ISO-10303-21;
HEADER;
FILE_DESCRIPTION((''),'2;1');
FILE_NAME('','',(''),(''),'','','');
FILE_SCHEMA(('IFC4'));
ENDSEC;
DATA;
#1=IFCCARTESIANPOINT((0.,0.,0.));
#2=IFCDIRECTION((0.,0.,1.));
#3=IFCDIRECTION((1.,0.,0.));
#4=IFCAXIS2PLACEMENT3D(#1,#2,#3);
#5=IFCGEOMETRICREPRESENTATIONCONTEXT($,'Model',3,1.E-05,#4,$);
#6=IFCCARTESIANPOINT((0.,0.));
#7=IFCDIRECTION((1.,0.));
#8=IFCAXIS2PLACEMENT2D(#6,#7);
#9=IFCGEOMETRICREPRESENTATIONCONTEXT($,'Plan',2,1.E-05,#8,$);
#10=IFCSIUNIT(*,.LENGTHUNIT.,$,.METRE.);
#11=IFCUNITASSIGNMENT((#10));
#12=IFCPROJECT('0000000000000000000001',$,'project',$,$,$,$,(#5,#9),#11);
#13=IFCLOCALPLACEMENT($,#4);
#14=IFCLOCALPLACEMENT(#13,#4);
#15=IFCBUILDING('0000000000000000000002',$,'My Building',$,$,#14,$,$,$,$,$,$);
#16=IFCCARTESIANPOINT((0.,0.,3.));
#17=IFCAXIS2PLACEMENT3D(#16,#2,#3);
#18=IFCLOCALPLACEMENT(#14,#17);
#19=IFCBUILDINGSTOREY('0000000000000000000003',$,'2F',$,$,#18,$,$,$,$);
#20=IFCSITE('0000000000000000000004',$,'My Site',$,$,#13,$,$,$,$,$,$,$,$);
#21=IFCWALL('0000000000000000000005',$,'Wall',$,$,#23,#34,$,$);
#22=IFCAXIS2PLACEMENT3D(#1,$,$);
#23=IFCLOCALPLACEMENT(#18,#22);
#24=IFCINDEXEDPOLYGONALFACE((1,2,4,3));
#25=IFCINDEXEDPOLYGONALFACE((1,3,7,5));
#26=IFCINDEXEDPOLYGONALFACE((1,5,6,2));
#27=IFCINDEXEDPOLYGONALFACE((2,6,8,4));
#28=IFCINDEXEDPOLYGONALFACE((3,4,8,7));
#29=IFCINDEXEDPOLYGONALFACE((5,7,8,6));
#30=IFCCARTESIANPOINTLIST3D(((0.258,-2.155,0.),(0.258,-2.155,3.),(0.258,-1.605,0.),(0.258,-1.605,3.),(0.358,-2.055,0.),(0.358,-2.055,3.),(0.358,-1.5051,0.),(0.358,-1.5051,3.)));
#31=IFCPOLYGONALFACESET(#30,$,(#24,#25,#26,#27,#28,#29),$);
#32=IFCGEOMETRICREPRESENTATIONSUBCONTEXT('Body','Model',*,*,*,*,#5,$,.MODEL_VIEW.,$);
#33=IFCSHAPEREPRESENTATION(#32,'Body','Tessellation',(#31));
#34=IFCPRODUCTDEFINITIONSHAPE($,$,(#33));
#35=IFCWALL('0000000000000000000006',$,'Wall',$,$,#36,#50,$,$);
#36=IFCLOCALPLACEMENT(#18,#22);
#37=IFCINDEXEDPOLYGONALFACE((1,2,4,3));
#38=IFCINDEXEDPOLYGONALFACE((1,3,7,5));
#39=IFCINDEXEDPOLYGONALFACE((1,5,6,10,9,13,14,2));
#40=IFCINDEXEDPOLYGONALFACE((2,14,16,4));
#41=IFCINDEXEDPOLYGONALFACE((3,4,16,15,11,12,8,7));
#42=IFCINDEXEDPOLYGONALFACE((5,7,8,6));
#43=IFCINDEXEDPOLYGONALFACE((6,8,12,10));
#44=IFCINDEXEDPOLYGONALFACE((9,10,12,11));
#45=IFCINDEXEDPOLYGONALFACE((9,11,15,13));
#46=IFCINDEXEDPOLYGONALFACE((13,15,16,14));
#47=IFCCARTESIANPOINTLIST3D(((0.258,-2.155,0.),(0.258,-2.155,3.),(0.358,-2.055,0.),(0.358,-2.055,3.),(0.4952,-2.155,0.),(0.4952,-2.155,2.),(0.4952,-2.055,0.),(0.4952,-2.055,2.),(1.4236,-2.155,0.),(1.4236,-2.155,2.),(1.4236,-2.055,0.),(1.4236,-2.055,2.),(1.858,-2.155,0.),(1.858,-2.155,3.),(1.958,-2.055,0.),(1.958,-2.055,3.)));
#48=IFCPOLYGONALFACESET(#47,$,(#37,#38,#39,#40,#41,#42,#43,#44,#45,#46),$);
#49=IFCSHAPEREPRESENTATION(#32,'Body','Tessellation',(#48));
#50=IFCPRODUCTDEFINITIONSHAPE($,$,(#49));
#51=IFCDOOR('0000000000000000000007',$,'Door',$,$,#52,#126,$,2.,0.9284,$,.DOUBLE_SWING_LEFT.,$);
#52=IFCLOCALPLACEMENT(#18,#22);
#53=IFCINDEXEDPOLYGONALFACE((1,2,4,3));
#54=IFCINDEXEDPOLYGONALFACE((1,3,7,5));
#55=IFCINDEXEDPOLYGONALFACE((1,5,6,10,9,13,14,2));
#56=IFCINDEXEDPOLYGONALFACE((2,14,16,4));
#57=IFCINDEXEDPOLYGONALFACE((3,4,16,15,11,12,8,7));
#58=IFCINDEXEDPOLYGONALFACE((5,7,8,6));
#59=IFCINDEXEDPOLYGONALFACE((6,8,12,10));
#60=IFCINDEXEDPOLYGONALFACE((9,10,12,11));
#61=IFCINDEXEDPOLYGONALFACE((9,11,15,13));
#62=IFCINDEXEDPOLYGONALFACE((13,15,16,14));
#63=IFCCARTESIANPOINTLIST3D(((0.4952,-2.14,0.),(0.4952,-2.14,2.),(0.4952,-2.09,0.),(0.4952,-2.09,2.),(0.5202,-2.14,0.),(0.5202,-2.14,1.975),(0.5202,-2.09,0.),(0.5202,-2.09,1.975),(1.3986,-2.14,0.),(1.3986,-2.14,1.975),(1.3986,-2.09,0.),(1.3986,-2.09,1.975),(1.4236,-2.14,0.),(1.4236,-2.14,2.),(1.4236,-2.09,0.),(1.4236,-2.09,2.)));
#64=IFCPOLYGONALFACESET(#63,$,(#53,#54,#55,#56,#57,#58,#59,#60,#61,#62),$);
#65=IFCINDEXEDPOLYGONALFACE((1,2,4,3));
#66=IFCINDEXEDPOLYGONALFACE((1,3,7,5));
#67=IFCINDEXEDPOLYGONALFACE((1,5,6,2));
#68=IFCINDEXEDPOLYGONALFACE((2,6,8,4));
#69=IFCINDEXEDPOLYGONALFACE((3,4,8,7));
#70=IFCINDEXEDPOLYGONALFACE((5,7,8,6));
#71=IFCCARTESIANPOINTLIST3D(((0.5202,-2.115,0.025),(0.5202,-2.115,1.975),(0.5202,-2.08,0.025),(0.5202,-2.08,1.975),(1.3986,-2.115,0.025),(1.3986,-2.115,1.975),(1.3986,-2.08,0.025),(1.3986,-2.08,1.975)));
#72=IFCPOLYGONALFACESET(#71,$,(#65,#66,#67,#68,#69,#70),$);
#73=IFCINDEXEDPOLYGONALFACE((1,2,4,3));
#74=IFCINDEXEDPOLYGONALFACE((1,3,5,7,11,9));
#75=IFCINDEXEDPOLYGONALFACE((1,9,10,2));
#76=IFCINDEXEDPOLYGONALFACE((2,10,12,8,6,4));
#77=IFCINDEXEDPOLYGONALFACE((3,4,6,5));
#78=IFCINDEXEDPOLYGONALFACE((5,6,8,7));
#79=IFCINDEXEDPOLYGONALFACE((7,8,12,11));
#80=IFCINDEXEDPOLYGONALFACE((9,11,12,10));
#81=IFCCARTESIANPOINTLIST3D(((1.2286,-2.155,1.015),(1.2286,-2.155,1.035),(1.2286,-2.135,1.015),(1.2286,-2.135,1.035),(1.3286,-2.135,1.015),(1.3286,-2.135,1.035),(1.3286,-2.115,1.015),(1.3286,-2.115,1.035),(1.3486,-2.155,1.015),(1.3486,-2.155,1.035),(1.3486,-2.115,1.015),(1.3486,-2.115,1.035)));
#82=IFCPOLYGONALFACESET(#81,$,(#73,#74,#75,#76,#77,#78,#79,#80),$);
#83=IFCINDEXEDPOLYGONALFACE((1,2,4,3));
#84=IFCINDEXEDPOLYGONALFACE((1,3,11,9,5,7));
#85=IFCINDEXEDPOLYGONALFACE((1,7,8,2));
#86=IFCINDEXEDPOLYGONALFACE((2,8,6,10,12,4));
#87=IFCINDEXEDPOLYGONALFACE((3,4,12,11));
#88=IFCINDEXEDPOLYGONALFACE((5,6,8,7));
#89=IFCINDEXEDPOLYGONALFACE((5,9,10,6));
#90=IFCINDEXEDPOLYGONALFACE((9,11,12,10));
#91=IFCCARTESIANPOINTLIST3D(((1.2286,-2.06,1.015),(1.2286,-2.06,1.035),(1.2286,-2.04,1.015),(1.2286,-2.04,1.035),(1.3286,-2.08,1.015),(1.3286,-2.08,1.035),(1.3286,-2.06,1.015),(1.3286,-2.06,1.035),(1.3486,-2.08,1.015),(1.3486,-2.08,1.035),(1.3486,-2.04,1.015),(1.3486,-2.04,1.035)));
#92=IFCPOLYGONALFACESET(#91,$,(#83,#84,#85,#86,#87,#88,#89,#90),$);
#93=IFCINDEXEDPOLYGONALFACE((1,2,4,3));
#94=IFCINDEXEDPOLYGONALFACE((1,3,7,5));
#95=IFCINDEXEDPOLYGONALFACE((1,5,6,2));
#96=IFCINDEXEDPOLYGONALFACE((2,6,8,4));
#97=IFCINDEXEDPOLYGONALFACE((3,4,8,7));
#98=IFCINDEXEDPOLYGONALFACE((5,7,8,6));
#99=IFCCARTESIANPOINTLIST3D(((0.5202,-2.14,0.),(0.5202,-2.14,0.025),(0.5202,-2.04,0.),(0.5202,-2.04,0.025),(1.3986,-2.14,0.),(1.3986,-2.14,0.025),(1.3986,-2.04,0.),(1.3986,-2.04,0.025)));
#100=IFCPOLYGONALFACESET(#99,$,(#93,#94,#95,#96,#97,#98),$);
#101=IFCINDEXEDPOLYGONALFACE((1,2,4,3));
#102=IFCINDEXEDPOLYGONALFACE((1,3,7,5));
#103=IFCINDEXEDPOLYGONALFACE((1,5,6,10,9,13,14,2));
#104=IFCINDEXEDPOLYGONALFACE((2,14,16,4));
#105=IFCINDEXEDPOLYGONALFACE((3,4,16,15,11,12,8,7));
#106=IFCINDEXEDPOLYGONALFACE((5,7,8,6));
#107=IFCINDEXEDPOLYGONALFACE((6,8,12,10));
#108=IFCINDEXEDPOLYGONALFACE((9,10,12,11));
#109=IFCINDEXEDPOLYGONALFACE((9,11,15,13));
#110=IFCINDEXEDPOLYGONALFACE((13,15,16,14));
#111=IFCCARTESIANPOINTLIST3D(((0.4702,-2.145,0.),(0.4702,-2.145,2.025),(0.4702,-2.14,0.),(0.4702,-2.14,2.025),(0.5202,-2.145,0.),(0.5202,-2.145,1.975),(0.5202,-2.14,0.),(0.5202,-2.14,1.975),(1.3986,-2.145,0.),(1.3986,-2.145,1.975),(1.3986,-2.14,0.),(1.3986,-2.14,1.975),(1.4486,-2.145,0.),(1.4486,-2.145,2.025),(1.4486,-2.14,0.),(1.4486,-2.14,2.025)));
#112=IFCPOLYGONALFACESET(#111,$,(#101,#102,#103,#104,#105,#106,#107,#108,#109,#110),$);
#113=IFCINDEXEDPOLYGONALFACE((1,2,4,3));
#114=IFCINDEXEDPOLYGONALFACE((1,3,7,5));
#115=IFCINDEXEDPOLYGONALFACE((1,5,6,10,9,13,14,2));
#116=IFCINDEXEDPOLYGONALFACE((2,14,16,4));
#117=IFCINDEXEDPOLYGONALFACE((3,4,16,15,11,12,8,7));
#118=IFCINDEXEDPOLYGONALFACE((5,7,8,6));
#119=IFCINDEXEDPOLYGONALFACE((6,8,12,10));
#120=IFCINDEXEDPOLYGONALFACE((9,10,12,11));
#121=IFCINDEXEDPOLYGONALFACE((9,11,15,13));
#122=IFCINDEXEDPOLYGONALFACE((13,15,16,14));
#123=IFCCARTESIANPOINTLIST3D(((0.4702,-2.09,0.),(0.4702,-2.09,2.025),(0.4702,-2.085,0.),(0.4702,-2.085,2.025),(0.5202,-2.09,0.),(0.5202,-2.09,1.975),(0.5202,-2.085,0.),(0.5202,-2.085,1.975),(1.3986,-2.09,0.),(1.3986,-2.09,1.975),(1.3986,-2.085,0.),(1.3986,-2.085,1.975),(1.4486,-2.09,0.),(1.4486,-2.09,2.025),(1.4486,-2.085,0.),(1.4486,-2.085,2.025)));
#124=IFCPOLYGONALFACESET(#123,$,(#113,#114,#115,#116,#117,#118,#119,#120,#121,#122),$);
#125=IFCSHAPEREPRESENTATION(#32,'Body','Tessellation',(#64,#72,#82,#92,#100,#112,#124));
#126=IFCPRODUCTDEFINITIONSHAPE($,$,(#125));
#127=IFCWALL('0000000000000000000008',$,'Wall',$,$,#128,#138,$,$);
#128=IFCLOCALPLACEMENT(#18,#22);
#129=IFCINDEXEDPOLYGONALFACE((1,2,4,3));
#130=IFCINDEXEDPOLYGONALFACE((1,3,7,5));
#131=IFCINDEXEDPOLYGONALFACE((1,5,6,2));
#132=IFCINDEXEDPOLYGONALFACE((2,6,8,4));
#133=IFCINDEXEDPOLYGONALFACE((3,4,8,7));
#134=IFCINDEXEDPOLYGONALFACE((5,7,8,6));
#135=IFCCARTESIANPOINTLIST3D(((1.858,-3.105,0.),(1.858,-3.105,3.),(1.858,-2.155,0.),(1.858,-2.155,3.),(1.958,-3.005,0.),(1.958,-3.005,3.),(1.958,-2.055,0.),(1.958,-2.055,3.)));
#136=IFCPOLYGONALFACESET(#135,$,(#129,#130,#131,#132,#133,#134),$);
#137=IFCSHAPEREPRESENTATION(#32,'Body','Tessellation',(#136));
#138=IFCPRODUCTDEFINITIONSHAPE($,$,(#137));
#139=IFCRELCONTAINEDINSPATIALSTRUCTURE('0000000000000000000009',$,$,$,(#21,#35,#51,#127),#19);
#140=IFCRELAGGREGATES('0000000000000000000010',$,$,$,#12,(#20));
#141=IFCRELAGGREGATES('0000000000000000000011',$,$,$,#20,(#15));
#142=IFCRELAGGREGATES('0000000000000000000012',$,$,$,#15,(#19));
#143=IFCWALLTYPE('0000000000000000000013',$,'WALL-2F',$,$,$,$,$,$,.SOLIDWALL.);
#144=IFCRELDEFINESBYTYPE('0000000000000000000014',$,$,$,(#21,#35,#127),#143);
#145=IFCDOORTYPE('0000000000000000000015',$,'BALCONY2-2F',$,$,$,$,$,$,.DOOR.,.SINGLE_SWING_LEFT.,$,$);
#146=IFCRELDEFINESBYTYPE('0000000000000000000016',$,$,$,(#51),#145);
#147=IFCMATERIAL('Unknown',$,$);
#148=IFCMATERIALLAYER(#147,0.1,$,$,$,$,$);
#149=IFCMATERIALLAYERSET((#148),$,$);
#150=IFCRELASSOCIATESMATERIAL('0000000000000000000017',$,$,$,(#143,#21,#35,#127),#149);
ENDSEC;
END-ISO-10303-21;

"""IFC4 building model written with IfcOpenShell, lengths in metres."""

from ifc_helpers import new_model, entity, si_unit, frame, origin_with_axes, origin_2d_with_axis, place, context, subcontext, project, spatial, line, indexed_curve, outline, extrude, shape, source, transform, mapped, material, layer, layer_set, layer_usage, type_object, type_shapes, element, fill, save


model = new_model("IFC4")

# Units and contexts
model_context = context("Model", 3, precision=1e-05, world=origin_with_axes())
plan_context = context("Plan", 2, precision=1e-05, world=origin_2d_with_axis())
body_context_1 = subcontext(model_context, "Body", "Model", "MODEL_VIEW")
body_context_2 = subcontext(plan_context, "Body", "Plan", "PLAN_VIEW")
ifc_project = project(units=[si_unit("LENGTHUNIT", "METRE")], contexts=[model_context, plan_context])

# Site, building, storey
site_placement = place(None, origin_with_axes())
site = spatial("IfcSite", under=ifc_project, at=site_placement, Name="My Site")
building_placement = place(site_placement, origin_with_axes())
building = spatial("IfcBuilding", under=site, at=building_placement, Name="My Building")
storey_placement = place(building_placement, frame((0.0, 0.0, 3.0), z_axis=(0.0, 0.0, 1.0), x_axis=(1.0, 0.0, 0.0)))
storey = spatial("IfcBuildingStorey", under=building, at=storey_placement, Name="2F")

# Shared definitions
ifc_material = material(Name="Unknown")

# Shared definitions
ifc_layer_1 = layer(ifc_material, 0.1)
ifc_layer_set_1 = layer_set([ifc_layer_1])
wall_type = type_object("IfcWallType", Name="WALL-2F", PredefinedType="SOLIDWALL", material=ifc_layer_set_1)

# Wall
ifc_layer_usage_1 = layer_usage(ifc_layer_set_1, "AXIS2", "POSITIVE", 0.0)
wall_1_placement = place(storey_placement, frame((0.258, -1.605, 0.0), z_axis=(0.0, 0.0, 1.0), x_axis=(0.0, -1.0, 0.0)))
element("IfcWall", 1, at=wall_1_placement, inside=storey, type_object=wall_type, material=ifc_layer_usage_1, Name="Wall", context=body_context_1, shape_type="SweptSolid", body=[
    extrude(outline(indexed_curve([(0.0, 0.0), (-0.0999, 0.1), (0.45, 0.1), (0.55, 0.0)], segments=[line(1, 2, 3, 4, 1)])), origin_with_axes(), (0.0, 0.0, 1.0), 3.0),
])

# Wall, opening, door
ifc_layer_usage_2 = layer_usage(ifc_layer_set_1, "AXIS2", "POSITIVE", 0.0)
wall_2_placement = place(storey_placement, frame((0.258, -2.155, 0.0), z_axis=(0.0, 0.0, 1.0), x_axis=(1.0, 0.0, 0.0)))
wall_2 = element("IfcWall", 2, at=wall_2_placement, inside=storey, type_object=wall_type, material=ifc_layer_usage_2, Name="Wall", context=body_context_1, shape_type="SweptSolid", body=[
    extrude(outline(indexed_curve([(0.0, 0.0), (0.1, 0.1), (1.7, 0.1), (1.6, 0.0)], segments=[line(1, 2, 3, 4, 1)])), origin_with_axes(), (0.0, 0.0, 1.0), 3.0),
])
shared_shape_1 = source(origin_with_axes(), body_context_1, "Body", "SweptSolid", [
    extrude(outline(indexed_curve([(0.0, 0.0), (0.9284, 0.0), (0.9284, 2.0), (0.0, 2.0)], segments=[line(1, 2, 3, 4, 1)])), frame((0.0, -0.6, 0.0), z_axis=(0.0, -1.0, 0.0), x_axis=(1.0, 0.0, 0.0)), (0.0, 0.0, -1.0), 1.2),
])
opening_1_placement = place(wall_2_placement, frame((0.2372, 0.015, 0.0), z_axis=(0.0, 0.0, 1.0), x_axis=(1.0, -0.000001, 0.0)))
opening_1 = element("IfcOpeningElement", 3, at=opening_1_placement, cuts=wall_2, PredefinedType="OPENING", context=body_context_1, shape_type="MappedRepresentation", body=[
    mapped(shared_shape_1, transform((0.0, 0.0, 0.0), x_axis=(1.0, 0.0, 0.0), y_axis=(0.0, 1.0, 0.0), z_axis=(0.0, 0.0, 1.0), scale=1.0)),
])
door_type_1 = type_object("IfcDoorType", Name="BALCONY2-2F", OperationType="SINGLE_SWING_LEFT", PredefinedType="DOOR")
shared_shape_2 = source(origin_with_axes(), body_context_1, "Body", "SweptSolid", [
    extrude(outline(indexed_curve([(0.0, 0.0), (0.0, 2.0), (0.9284, 2.0), (0.9284, 0.0), (0.9034, 0.0), (0.9034, 1.975), (0.025, 1.975), (0.025, 0.0)], segments=[line(1, 2, 3, 4, 5, 6, 7, 8, 1)])), frame((0.0, 0.0, 0.0), z_axis=(0.0, -1.0, 0.0), x_axis=(1.0, 0.0, 0.0)), (0.0, 0.0, -1.0), 0.05),
    extrude(outline(indexed_curve([(0.0, 0.0), (0.8784, 0.0), (0.8784, 0.035), (0.0, 0.035)], segments=[line(1, 2, 3, 4, 1)])), frame((0.025, 0.025, 0.025), z_axis=(0.0, 0.0, 1.0), x_axis=(1.0, 0.0, 0.0)), (0.0, 0.0, 1.0), 1.95),
    extrude(outline(indexed_curve([(0.0, 0.0), (0.0, -0.04), (-0.12, -0.04), (-0.12, -0.02), (-0.02, -0.02), (-0.02, 0.0)], segments=[line(1, 2, 3, 4, 5, 6, 1)])), frame((0.8534, 0.025, 1.015), z_axis=(0.0, 0.0, 1.0), x_axis=(1.0, 0.0, 0.0)), (0.0, 0.0, 1.0), 0.02),
    extrude(outline(indexed_curve([(0.0, 0.0), (0.0, 0.04), (-0.12, 0.04), (-0.12, 0.02), (-0.02, 0.02), (-0.02, 0.0)], segments=[line(1, 2, 3, 4, 5, 6, 1)])), frame((0.8534, 0.06, 1.015), z_axis=(0.0, 0.0, 1.0), x_axis=(1.0, 0.0, 0.0)), (0.0, 0.0, 1.0), 0.02),
    extrude(outline(indexed_curve([(0.0, 0.0), (0.8784, 0.0), (0.8784, 0.1), (0.0, 0.1)], segments=[line(1, 2, 3, 4, 1)])), frame((0.025, 0.0, 0.0), z_axis=(0.0, 0.0, 1.0), x_axis=(1.0, 0.0, 0.0)), (0.0, 0.0, 1.0), 0.025),
    extrude(outline(indexed_curve([(0.0, 0.0), (0.0, 2.025), (0.9784, 2.025), (0.9784, 0.0), (0.9284, 0.0), (0.9284, 1.975), (0.05, 1.975), (0.05, 0.0)], segments=[line(1, 2, 3, 4, 5, 6, 7, 8, 1)])), frame((-0.025, -0.005, 0.0), z_axis=(0.0, -1.0, 0.0), x_axis=(1.0, 0.0, 0.0)), (0.0, 0.0, -1.0), 0.005),
    extrude(outline(indexed_curve([(0.0, 0.0), (0.0, 2.025), (0.9784, 2.025), (0.9784, 0.0), (0.9284, 0.0), (0.9284, 1.975), (0.05, 1.975), (0.05, 0.0)], segments=[line(1, 2, 3, 4, 5, 6, 7, 8, 1)])), frame((-0.025, 0.05, 0.0), z_axis=(0.0, -1.0, 0.0), x_axis=(1.0, 0.0, 0.0)), (0.0, 0.0, -1.0), 0.005),
])
shared_shape_3 = source(origin_with_axes(), body_context_2, "Body", "Curve2D", [
    entity("IfcIndexedPolyCurve", entity("IfcCartesianPointList2D", [[0.0, 0.0], [0.025, 0.0], [0.025, 0.05], [0.0, 0.05]]), [entity("IfcLineIndex", [1, 2, 3, 4, 1])]),
    entity("IfcIndexedPolyCurve", entity("IfcCartesianPointList2D", [[0.9284, 0.0], [0.9034, 0.0], [0.9034, 0.05], [0.9284, 0.05]]), [entity("IfcLineIndex", [1, 2, 3, 4, 1])]),
    entity("IfcIndexedPolyCurve", entity("IfcCartesianPointList2D", [[0.025, 0.05], [0.025, -0.8284], [0.06, -0.8284]])),
    entity("IfcTrimmedCurve", entity("IfcEllipse", entity("IfcAxis2Placement2D", entity("IfcCartesianPoint", [0.06, 0.05]), entity("IfcDirection", [1.0, 0.0])), 0.8434, 0.8784), [entity("IfcCartesianPoint", [0.06, -0.8284])], [entity("IfcCartesianPoint", [0.06, 0.9284])], True, "CARTESIAN"),
    entity("IfcIndexedPolyCurve", entity("IfcCartesianPointList2D", [[0.025, 0.05], [0.06, 0.05], [0.06, 0.9284], [0.025, 0.9284]]), [entity("IfcLineIndex", [1, 2, 3, 4, 1])]),
])
type_shapes(door_type_1, [shared_shape_2, shared_shape_3])
door_1_placement = place(opening_1_placement, frame((0.0, 0.0, 0.0), z_axis=(0.0, 0.0, 1.0), x_axis=(1.0, 0.0, 0.0)))
door_1 = element("IfcDoor", 4, at=door_1_placement, inside=storey, type_object=door_type_1, Name="Door", OperationType="DOUBLE_SWING_LEFT", OverallHeight=2.0, OverallWidth=0.9284, shapes=[
    shape(body_context_1, "Body", "MappedRepresentation", [mapped(shared_shape_2, transform((0.0, 0.0, 0.0), x_axis=(1.0, 0.0, 0.0), y_axis=(0.0, 1.0, 0.0), z_axis=(0.0, 0.0, 1.0), scale=1.0))]),
    shape(body_context_2, "Body", "MappedRepresentation", [mapped(shared_shape_3, transform((0.0, 0.0, 0.0), x_axis=(1.0, 0.0, 0.0), y_axis=(0.0, 1.0, 0.0), z_axis=(0.0, 0.0, 1.0), scale=1.0))]),
])
fill(opening_1, door_1)

# Wall
ifc_layer_usage_3 = layer_usage(ifc_layer_set_1, "AXIS2", "POSITIVE", 0.0)
wall_3_placement = place(storey_placement, frame((1.858, -2.155, 0.0), z_axis=(0.0, 0.0, 1.0), x_axis=(0.0, -1.0, 0.0)))
element("IfcWall", 5, at=wall_3_placement, inside=storey, type_object=wall_type, material=ifc_layer_usage_3, Name="Wall", context=body_context_1, shape_type="SweptSolid", body=[
    extrude(outline(indexed_curve([(0.0, 0.0), (-0.1, 0.1), (0.85, 0.1), (0.95, 0.0)], segments=[line(1, 2, 3, 4, 1)])), origin_with_axes(), (0.0, 0.0, 1.0), 3.0),
])

save(model, "model.ifc")
